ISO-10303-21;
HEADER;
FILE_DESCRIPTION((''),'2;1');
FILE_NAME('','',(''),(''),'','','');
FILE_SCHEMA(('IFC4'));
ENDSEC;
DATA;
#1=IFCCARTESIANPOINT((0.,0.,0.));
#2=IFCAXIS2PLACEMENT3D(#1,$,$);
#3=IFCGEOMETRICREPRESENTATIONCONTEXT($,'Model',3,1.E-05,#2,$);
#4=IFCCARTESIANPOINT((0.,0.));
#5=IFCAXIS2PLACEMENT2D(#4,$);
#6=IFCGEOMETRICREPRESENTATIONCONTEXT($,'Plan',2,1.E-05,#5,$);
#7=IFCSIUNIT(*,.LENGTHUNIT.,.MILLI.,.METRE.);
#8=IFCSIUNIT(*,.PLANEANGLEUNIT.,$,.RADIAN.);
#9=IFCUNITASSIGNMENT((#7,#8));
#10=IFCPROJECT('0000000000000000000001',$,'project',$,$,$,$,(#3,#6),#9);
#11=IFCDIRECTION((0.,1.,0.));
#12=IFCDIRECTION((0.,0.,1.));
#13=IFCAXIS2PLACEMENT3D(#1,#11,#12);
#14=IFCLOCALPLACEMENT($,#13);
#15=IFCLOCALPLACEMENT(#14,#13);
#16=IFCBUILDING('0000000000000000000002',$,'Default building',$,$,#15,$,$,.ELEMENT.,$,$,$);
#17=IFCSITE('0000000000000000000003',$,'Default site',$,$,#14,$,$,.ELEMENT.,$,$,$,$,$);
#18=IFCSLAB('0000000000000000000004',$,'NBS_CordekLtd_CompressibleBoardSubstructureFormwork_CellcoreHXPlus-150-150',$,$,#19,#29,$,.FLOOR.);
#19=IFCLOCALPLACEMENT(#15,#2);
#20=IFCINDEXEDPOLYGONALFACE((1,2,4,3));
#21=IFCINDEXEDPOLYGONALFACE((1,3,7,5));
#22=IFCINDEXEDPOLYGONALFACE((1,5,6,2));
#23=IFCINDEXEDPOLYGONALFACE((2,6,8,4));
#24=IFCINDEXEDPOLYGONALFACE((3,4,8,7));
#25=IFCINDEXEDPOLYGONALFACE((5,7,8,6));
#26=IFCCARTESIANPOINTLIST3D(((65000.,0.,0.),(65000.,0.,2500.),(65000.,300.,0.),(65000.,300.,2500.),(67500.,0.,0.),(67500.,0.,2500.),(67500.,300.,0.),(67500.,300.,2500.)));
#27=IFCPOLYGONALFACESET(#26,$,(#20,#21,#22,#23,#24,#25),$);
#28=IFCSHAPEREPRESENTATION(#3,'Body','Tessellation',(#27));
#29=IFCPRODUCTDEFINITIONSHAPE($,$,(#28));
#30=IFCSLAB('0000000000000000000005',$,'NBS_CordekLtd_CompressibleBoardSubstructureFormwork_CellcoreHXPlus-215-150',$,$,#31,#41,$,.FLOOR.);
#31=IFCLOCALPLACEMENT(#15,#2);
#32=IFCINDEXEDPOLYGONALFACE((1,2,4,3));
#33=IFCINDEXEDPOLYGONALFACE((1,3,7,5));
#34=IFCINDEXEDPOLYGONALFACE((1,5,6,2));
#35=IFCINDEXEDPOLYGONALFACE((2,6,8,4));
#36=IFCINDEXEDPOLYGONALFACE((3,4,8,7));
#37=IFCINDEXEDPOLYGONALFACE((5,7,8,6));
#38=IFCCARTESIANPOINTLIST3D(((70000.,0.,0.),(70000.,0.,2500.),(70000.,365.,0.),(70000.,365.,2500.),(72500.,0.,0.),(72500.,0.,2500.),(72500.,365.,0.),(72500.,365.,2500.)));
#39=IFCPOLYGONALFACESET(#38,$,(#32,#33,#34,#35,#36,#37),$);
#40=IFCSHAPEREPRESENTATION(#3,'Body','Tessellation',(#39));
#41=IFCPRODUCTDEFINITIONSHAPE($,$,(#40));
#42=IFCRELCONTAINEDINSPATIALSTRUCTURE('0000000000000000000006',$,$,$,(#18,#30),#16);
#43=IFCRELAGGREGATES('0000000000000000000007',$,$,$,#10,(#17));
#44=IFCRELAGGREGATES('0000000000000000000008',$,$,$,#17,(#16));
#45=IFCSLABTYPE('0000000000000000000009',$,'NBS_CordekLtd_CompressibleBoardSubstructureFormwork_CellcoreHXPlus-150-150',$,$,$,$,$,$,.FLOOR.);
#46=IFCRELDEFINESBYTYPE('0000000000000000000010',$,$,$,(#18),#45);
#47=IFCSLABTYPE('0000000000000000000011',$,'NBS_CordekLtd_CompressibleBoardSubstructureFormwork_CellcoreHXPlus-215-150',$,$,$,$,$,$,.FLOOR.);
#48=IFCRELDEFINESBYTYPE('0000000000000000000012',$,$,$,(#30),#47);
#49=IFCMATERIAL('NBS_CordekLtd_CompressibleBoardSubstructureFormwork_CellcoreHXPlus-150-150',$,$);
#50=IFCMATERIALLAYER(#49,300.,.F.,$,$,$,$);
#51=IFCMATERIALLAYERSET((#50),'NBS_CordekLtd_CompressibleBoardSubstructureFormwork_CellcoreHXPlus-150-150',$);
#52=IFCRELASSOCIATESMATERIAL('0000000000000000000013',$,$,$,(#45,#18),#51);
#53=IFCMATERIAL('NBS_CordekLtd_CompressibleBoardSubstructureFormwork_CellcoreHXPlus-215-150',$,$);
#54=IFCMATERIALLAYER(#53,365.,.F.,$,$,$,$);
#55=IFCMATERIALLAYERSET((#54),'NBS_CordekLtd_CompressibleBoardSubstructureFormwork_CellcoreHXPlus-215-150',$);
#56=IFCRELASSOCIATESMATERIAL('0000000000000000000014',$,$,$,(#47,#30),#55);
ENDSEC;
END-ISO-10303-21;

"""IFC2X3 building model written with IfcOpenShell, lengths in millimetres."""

from ifc_helpers import new_model, si_unit, frame, frame_2d, origin, origin_with_axes, origin_2d, place, context, project, spatial, rectangle, extrude, material, layer, layer_set, layer_usage, type_object, element, save


model = new_model("IFC2X3")

# Units and contexts
model_context = context("Model", 3, precision=1e-05, world=origin())
plan_context = context("Plan", 2, precision=1e-05, world=origin_2d())
ifc_project = project(units=[si_unit("LENGTHUNIT", "METRE", prefix="MILLI"), si_unit("PLANEANGLEUNIT", "RADIAN")], contexts=[model_context, plan_context])

# Site, building
site_placement = place(None, frame((0.0, 0.0, 0.0), z_axis=(0.0, 1.0, 0.0), x_axis=(0.0, 0.0, 1.0)))
site = spatial("IfcSite", under=ifc_project, at=site_placement, Name="Default site", CompositionType="ELEMENT")
building_placement = place(site_placement, frame((0.0, 0.0, 0.0), z_axis=(0.0, 1.0, 0.0), x_axis=(0.0, 0.0, 1.0)))
building = spatial("IfcBuilding", under=site, at=building_placement, Name="Default building", CompositionType="ELEMENT")

# Slabs
ifc_material_1 = material(Name="NBS_CordekLtd_CompressibleBoardSubstructureFormwork_CellcoreHXPlus-150-150")
ifc_layer_1 = layer(ifc_material_1, 300.0, ventilated=False)
ifc_layer_set_1 = layer_set([ifc_layer_1], Name="NBS_CordekLtd_CompressibleBoardSubstructureFormwork_CellcoreHXPlus-150-150")
ifc_layer_usage_1 = layer_usage(ifc_layer_set_1, "AXIS3", "NEGATIVE", 0.0)
slab_type_1 = type_object("IfcSlabType", Name="NBS_CordekLtd_CompressibleBoardSubstructureFormwork_CellcoreHXPlus-150-150", PredefinedType="FLOOR", material=ifc_layer_set_1)
slab_1_placement = place(None, frame((0.0, 65000.0, 0.0)))
element("IfcSlab", 1, at=slab_1_placement, inside=building, type_object=slab_type_1, material=ifc_layer_usage_1, Name="NBS_CordekLtd_CompressibleBoardSubstructureFormwork_CellcoreHXPlus-150-150", PredefinedType="FLOOR", context=model_context, shape_type="SweptSolid", body=[
    extrude(rectangle(XDim=2500.0, YDim=2500.0, at=frame_2d((1250.0, 1250.0))), origin_with_axes(), (0.0, 0.0, 1.0), 300.0),
])
ifc_material_2 = material(Name="NBS_CordekLtd_CompressibleBoardSubstructureFormwork_CellcoreHXPlus-215-150")
ifc_layer_2 = layer(ifc_material_2, 365.0, ventilated=False)
ifc_layer_set_2 = layer_set([ifc_layer_2], Name="NBS_CordekLtd_CompressibleBoardSubstructureFormwork_CellcoreHXPlus-215-150")
ifc_layer_usage_2 = layer_usage(ifc_layer_set_2, "AXIS3", "NEGATIVE", 0.0)
slab_type_2 = type_object("IfcSlabType", Name="NBS_CordekLtd_CompressibleBoardSubstructureFormwork_CellcoreHXPlus-215-150", PredefinedType="FLOOR", material=ifc_layer_set_2)
slab_2_placement = place(None, frame((0.0, 70000.0, 0.0)))
element("IfcSlab", 2, at=slab_2_placement, inside=building, type_object=slab_type_2, material=ifc_layer_usage_2, Name="NBS_CordekLtd_CompressibleBoardSubstructureFormwork_CellcoreHXPlus-215-150", PredefinedType="FLOOR", context=model_context, shape_type="SweptSolid", body=[
    extrude(rectangle(XDim=2500.0, YDim=2500.0, at=frame_2d((1250.0, 1250.0))), origin_with_axes(), (0.0, 0.0, 1.0), 365.0),
])

save(model, "model.ifc")
